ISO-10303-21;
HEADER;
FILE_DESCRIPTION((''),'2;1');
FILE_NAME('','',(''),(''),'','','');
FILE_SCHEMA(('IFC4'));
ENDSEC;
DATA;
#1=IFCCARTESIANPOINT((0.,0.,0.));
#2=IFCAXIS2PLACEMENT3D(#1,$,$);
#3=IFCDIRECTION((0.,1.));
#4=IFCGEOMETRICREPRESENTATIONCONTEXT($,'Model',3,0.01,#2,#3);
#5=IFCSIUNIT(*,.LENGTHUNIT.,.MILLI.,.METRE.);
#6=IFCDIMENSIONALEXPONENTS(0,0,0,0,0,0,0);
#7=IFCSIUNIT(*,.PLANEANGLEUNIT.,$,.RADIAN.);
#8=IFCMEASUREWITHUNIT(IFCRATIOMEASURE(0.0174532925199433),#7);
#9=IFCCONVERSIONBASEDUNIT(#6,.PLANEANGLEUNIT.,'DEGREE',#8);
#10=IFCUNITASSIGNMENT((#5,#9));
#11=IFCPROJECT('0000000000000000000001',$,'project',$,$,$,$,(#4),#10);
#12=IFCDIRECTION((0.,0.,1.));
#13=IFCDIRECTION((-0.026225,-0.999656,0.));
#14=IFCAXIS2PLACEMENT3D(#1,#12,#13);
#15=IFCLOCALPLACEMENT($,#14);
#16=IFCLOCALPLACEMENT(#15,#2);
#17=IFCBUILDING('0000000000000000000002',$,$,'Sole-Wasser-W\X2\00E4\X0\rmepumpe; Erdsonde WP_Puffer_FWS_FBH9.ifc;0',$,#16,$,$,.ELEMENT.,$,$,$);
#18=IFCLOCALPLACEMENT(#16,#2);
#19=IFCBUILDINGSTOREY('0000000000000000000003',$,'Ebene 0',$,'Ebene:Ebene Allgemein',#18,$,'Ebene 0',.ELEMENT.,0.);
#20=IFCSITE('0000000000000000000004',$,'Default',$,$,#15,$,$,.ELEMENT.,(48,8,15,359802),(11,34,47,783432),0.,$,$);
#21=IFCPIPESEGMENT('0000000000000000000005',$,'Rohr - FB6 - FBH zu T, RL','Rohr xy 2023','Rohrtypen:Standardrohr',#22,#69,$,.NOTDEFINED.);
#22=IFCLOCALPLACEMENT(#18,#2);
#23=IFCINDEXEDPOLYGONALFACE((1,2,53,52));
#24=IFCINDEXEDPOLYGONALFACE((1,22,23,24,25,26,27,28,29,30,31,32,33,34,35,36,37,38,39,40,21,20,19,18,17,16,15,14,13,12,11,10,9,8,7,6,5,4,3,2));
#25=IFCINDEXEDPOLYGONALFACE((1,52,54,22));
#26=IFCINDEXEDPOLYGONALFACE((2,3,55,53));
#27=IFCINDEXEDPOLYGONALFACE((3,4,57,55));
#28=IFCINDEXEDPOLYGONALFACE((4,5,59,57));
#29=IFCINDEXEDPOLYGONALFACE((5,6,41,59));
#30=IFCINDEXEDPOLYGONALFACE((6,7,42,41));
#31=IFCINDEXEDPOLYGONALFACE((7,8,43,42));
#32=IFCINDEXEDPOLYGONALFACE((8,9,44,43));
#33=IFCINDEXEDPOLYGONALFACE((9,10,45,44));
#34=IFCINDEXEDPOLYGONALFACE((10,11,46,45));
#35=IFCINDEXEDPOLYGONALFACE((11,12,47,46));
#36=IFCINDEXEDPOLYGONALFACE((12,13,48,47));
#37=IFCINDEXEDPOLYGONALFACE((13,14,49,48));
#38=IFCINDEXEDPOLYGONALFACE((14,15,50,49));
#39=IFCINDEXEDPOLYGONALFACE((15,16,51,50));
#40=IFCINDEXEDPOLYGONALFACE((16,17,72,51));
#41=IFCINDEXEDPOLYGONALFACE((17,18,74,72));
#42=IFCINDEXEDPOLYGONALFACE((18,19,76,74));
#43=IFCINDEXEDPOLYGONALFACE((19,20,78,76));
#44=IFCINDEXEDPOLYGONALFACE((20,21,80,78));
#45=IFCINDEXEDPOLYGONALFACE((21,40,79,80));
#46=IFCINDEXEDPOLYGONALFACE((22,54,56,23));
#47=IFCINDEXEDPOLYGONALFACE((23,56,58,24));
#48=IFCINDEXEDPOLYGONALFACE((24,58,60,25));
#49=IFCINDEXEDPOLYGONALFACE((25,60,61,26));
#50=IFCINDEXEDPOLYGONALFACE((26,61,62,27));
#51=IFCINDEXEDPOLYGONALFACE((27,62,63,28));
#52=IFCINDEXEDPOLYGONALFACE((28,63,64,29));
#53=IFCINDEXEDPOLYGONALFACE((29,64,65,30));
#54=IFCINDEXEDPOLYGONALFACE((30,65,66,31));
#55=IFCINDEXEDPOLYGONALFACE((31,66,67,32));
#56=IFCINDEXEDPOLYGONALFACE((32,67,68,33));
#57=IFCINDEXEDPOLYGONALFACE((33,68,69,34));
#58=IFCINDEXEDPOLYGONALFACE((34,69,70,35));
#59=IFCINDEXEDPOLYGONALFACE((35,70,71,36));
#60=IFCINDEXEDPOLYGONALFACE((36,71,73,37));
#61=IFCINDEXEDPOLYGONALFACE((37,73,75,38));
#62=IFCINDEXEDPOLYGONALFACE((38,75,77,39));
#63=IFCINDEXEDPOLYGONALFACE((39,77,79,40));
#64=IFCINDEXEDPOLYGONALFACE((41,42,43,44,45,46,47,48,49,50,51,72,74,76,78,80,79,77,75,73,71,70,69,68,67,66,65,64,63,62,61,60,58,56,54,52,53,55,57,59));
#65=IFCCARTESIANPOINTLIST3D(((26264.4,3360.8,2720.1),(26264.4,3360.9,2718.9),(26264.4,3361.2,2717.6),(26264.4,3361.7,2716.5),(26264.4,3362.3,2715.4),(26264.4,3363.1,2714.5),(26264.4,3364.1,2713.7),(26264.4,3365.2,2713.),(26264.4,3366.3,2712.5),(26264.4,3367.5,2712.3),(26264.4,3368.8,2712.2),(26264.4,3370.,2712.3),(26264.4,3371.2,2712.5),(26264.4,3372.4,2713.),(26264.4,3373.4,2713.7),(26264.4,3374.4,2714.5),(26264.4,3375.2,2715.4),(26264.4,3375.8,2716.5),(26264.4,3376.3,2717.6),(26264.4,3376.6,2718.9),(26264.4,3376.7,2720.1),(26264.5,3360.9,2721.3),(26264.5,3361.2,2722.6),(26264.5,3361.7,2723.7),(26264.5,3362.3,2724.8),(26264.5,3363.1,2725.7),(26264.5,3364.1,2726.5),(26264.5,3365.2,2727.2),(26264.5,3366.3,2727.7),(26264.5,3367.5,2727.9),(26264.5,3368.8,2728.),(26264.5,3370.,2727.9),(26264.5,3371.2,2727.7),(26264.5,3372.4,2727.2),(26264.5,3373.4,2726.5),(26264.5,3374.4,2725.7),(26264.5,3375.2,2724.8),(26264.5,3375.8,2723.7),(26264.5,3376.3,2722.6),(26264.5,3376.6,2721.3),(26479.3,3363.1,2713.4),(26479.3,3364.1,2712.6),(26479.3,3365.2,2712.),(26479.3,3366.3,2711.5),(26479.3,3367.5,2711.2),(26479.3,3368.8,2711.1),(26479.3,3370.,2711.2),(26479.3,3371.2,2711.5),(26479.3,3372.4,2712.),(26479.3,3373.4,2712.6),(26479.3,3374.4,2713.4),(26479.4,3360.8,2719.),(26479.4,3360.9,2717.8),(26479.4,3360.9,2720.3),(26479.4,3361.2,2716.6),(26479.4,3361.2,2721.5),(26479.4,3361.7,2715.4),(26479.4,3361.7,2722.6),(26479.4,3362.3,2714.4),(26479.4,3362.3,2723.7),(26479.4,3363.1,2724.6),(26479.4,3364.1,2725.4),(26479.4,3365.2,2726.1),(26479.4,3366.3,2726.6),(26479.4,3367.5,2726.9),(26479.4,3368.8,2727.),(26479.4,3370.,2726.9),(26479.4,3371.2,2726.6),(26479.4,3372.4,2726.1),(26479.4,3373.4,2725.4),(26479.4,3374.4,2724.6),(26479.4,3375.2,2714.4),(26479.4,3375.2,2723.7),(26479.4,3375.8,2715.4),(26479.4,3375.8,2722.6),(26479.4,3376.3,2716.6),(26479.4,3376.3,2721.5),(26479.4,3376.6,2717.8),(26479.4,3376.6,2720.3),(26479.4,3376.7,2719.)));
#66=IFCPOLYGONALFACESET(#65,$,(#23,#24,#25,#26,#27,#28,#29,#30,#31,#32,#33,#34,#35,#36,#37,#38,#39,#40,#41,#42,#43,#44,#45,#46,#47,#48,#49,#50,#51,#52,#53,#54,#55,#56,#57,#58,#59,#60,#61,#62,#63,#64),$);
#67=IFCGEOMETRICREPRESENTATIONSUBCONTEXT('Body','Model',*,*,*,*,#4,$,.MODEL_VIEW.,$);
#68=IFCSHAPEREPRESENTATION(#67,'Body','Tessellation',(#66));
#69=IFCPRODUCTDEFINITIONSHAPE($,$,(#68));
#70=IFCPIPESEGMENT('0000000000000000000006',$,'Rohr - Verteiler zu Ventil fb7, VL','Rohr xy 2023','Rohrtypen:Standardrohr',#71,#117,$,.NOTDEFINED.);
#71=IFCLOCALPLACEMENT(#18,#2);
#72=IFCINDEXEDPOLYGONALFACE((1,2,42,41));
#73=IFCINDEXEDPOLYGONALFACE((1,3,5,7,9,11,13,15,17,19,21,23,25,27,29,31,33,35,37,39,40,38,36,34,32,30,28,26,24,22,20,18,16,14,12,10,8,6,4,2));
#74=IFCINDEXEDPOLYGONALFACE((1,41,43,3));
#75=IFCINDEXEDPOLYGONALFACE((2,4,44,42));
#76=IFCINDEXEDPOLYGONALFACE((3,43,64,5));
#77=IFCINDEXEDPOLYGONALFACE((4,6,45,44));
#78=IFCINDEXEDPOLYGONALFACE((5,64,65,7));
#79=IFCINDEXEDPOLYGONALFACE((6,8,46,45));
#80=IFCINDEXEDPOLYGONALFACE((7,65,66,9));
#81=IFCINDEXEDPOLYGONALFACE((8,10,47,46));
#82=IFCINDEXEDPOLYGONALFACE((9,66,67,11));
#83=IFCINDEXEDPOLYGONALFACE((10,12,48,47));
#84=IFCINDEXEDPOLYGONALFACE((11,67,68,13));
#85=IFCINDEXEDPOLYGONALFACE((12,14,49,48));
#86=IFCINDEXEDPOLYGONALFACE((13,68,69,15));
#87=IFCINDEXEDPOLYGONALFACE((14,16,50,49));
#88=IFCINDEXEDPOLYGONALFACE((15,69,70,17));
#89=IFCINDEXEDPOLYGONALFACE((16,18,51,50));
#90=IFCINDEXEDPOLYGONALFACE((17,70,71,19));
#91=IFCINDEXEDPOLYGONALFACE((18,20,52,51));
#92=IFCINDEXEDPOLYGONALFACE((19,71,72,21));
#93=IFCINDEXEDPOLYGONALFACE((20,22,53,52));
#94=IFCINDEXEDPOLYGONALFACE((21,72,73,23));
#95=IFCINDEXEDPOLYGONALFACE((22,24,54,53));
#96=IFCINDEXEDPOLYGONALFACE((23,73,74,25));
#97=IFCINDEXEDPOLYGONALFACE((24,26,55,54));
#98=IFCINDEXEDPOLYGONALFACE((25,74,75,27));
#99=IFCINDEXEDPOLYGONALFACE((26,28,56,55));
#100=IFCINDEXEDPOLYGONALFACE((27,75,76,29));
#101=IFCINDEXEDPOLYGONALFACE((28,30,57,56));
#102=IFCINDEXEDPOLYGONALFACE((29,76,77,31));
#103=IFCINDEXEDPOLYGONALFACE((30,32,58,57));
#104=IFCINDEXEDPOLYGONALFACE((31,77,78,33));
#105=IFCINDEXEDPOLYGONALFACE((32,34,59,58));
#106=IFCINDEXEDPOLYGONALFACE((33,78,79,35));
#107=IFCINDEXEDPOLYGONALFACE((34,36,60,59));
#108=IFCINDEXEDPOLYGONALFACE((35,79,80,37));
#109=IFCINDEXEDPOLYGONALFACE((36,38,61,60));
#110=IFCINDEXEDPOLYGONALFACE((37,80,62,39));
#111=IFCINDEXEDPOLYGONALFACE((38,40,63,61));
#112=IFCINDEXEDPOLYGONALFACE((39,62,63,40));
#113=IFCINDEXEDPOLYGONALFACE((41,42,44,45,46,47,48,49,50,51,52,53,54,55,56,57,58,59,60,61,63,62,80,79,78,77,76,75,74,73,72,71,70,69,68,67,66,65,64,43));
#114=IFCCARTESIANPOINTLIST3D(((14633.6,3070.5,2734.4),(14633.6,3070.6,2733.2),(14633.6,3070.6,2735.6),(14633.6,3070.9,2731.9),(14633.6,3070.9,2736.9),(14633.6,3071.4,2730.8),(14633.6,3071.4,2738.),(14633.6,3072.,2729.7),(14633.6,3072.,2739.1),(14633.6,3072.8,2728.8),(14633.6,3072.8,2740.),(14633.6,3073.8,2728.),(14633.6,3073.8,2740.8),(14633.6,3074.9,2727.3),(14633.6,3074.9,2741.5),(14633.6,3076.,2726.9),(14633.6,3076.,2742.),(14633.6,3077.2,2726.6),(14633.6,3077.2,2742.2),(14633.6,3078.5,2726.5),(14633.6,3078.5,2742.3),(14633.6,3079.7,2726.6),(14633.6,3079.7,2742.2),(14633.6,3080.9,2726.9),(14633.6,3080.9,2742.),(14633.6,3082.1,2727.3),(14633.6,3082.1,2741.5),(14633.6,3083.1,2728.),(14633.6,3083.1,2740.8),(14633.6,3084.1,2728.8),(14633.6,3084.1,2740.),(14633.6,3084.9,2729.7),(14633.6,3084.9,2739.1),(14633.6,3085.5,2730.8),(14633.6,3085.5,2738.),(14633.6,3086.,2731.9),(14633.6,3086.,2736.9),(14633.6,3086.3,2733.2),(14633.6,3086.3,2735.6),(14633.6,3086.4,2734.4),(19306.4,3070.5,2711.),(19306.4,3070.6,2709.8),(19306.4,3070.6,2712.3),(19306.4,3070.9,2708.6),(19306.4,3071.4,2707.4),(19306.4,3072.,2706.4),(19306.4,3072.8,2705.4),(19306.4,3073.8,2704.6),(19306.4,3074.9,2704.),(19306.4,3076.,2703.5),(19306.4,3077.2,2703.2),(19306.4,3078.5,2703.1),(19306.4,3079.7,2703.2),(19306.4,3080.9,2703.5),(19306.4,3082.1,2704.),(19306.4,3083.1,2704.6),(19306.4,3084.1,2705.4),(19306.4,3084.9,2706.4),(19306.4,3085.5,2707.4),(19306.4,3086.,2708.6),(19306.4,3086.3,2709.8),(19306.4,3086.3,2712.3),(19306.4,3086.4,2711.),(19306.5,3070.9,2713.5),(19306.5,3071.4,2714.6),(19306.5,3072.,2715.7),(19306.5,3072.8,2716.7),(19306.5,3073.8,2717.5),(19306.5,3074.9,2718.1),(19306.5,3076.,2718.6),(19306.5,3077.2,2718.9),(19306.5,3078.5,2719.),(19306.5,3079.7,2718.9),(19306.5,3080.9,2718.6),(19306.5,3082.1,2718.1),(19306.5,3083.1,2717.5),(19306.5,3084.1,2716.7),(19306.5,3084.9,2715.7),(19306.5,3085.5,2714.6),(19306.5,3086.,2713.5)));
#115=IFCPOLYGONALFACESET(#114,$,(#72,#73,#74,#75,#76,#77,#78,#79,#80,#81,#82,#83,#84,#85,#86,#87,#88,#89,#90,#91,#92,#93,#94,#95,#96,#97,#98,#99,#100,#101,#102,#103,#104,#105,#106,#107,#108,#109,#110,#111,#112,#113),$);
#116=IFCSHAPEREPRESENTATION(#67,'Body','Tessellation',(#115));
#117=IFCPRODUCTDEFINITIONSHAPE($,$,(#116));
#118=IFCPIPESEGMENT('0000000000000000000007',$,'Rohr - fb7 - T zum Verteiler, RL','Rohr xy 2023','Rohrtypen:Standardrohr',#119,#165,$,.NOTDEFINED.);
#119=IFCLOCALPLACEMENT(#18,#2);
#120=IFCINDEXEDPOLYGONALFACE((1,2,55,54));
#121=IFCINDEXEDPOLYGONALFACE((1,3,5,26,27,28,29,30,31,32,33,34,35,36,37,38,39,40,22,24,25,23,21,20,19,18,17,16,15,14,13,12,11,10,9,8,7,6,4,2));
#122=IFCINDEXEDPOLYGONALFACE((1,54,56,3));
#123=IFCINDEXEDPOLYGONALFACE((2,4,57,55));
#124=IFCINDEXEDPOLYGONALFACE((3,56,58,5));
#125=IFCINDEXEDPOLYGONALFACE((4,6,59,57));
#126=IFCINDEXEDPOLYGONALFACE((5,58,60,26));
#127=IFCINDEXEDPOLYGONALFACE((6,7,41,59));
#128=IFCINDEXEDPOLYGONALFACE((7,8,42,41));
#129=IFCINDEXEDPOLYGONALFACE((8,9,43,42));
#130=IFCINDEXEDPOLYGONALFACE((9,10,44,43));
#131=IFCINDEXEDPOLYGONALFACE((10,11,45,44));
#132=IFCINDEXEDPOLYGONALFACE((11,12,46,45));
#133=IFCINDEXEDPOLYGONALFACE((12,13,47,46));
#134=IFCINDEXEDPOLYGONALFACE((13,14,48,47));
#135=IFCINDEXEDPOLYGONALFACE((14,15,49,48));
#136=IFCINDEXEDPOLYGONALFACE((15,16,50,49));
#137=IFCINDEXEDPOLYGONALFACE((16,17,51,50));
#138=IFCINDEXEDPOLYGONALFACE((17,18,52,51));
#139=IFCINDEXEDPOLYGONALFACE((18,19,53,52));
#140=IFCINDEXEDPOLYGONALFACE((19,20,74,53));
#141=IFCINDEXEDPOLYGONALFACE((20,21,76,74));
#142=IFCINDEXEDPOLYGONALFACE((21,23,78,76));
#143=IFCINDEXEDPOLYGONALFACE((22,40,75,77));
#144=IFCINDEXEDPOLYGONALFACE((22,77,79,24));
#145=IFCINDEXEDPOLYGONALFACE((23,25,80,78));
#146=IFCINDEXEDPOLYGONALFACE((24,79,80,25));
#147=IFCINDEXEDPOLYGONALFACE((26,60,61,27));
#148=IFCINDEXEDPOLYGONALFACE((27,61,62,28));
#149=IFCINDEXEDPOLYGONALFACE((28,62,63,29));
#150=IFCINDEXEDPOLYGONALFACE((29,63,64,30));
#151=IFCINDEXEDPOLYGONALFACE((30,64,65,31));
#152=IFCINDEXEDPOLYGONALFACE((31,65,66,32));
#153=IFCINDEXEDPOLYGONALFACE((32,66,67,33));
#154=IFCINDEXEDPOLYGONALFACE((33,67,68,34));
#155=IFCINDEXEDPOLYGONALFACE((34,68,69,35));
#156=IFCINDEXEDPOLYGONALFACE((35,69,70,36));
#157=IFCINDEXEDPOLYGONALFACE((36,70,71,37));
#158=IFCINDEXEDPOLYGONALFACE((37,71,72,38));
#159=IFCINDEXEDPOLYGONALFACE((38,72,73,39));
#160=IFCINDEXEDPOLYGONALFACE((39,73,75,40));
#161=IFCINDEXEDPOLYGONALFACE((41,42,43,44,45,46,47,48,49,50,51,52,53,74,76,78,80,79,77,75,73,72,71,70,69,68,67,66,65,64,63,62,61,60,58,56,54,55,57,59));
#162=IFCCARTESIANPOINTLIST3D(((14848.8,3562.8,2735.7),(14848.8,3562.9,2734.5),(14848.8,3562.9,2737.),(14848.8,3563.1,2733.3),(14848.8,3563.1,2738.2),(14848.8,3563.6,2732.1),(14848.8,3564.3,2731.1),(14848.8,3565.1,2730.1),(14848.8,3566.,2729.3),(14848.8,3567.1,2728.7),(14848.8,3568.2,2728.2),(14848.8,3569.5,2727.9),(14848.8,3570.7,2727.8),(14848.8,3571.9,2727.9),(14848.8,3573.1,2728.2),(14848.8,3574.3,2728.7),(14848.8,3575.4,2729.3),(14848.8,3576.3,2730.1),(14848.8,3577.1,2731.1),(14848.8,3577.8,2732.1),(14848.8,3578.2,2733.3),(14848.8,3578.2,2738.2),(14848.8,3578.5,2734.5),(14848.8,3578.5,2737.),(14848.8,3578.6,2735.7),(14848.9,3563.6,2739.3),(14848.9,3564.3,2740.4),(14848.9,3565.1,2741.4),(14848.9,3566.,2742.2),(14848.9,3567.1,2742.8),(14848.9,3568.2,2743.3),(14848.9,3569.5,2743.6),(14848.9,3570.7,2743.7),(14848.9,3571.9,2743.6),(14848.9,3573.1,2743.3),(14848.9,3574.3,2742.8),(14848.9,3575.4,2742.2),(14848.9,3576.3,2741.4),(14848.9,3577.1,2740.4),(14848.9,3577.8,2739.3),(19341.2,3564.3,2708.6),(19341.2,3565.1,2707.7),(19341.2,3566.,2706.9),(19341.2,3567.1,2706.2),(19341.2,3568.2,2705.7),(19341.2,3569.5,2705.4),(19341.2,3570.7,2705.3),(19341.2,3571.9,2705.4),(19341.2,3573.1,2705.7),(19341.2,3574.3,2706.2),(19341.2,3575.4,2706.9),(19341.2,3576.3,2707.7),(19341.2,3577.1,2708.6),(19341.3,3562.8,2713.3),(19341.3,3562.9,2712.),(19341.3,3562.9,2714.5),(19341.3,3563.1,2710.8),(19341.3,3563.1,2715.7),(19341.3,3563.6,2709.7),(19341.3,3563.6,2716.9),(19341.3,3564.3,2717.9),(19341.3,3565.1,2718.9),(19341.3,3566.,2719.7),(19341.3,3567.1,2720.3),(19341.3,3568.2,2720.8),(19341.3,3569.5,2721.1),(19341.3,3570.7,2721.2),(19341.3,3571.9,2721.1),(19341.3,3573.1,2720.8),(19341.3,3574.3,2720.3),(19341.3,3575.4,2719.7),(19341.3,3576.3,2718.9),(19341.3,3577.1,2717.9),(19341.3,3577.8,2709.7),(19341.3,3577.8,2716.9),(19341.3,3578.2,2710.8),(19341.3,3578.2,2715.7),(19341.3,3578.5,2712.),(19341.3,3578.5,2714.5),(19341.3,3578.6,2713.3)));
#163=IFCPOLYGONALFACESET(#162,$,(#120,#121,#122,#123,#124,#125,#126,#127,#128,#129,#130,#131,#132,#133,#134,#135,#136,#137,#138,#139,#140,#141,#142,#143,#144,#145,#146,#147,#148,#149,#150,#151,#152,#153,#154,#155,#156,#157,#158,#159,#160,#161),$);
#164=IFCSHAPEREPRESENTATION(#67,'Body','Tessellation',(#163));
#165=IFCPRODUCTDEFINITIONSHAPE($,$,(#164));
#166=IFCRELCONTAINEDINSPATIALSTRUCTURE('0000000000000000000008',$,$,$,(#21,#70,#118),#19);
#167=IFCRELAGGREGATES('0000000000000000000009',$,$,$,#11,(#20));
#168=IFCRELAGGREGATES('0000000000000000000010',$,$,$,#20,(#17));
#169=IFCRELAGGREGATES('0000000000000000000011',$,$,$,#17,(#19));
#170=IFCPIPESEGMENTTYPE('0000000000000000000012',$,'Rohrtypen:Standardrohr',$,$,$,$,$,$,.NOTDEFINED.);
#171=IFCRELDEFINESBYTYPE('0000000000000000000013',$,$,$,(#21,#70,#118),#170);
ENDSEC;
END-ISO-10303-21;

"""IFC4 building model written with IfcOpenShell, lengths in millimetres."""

from ifc_helpers import new_model, entity, si_unit, converted_unit, direction, frame, origin, place, context, subcontext, project, spatial, indexed_curve, outline, extrude, type_object, element, save


model = new_model("IFC4")

# Units and contexts
model_context = context("Model", 3, precision=0.01, world=origin(), true_north=direction((0.0, 1.0)))
body_context = subcontext(model_context, "Body", "Model", "MODEL_VIEW")
ifc_project = project(units=[si_unit("LENGTHUNIT", "METRE", prefix="MILLI"), converted_unit("PLANEANGLEUNIT", "DEGREE", entity("IfcRatioMeasure", 0.0174532925199433), si_unit("PLANEANGLEUNIT", "RADIAN"), dimensions=[0, 0, 0, 0, 0, 0, 0])], contexts=[model_context])

# Site, building, storey
site_placement = place(None, frame((0.0, 0.0, 0.0), z_axis=(0.0, 0.0, 1.0), x_axis=(-0.026225, -0.999656, 0.0)))
site = spatial("IfcSite", under=ifc_project, at=site_placement, Name="Default", CompositionType="ELEMENT", RefLatitude=(48, 8, 15, 359802), RefLongitude=(11, 34, 47, 783432), RefElevation=0.0)
building_placement = place(site_placement, origin())
building = spatial("IfcBuilding", under=site, at=building_placement, Description="Sole-Wasser-Wärmepumpe; Erdsonde WP_Puffer_FWS_FBH9.ifc;0", CompositionType="ELEMENT")
storey_placement = place(building_placement, origin())
storey = spatial("IfcBuildingStorey", under=building, at=storey_placement, Name="Ebene 0", ObjectType="Ebene:Ebene Allgemein", LongName="Ebene 0", CompositionType="ELEMENT", Elevation=0.0)

# Pipe segments
pipe_segment_type = type_object("IfcPipeSegmentType", Name="Rohrtypen:Standardrohr", PredefinedType="NOTDEFINED")
pipe_segment_1_placement = place(storey_placement, origin())
element("IfcPipeSegment", 1, at=pipe_segment_1_placement, inside=storey, type_object=pipe_segment_type, Name="Rohr - FB6 - FBH zu T, RL", Description="Rohr xy 2023", ObjectType="Rohrtypen:Standardrohr", PredefinedType="NOTDEFINED", context=body_context, shape_type="SweptSolid", body=[
    extrude(outline(indexed_curve([(7.9, 0.0), (7.8, 1.2), (7.6, 2.5), (7.1, 3.6), (6.4, 4.7), (5.6, 5.6), (4.7, 6.4), (3.6, 7.1), (2.5, 7.6), (1.2, 7.8), (0.0, 7.9), (-1.2, 7.8), (-2.5, 7.6), (-3.6, 7.1), (-4.7, 6.4), (-5.6, 5.6), (-6.4, 4.7), (-7.1, 3.6), (-7.6, 2.5), (-7.8, 1.2), (-7.9, 0.0), (-7.8, -1.2), (-7.6, -2.5), (-7.1, -3.6), (-6.4, -4.7), (-5.6, -5.6), (-4.7, -6.4), (-3.6, -7.1), (-2.5, -7.6), (-1.2, -7.8), (0.0, -7.9), (1.2, -7.8), (2.5, -7.6), (3.6, -7.1), (4.7, -6.4), (5.6, -5.6), (6.4, -4.7), (7.1, -3.6), (7.6, -2.5), (7.8, -1.2), (7.9, 0.0)], self_intersect=False)), frame((26479.4, 3368.8, 2719.0), z_axis=(-0.999988, 0.0, 0.005), x_axis=(0.0, 1.0, 0.0)), (0.0, 0.0, 1.0), 214.9),
])
pipe_segment_2_placement = place(storey_placement, origin())
element("IfcPipeSegment", 2, at=pipe_segment_2_placement, inside=storey, type_object=pipe_segment_type, Name="Rohr - Verteiler zu Ventil fb7, VL", Description="Rohr xy 2023", ObjectType="Rohrtypen:Standardrohr", PredefinedType="NOTDEFINED", context=body_context, shape_type="SweptSolid", body=[
    extrude(outline(indexed_curve([(7.9, 0.0), (7.8, 1.2), (7.6, 2.5), (7.1, 3.6), (6.4, 4.7), (5.6, 5.6), (4.7, 6.4), (3.6, 7.1), (2.5, 7.6), (1.2, 7.8), (0.0, 7.9), (-1.2, 7.8), (-2.5, 7.6), (-3.6, 7.1), (-4.7, 6.4), (-5.6, 5.6), (-6.4, 4.7), (-7.1, 3.6), (-7.6, 2.5), (-7.8, 1.2), (-7.9, 0.0), (-7.8, -1.2), (-7.6, -2.5), (-7.1, -3.6), (-6.4, -4.7), (-5.6, -5.6), (-4.7, -6.4), (-3.6, -7.1), (-2.5, -7.6), (-1.2, -7.8), (0.0, -7.9), (1.2, -7.8), (2.5, -7.6), (3.6, -7.1), (4.7, -6.4), (5.6, -5.6), (6.4, -4.7), (7.1, -3.6), (7.6, -2.5), (7.8, -1.2), (7.9, 0.0)], self_intersect=False)), frame((19306.4, 3078.5, 2711.0), z_axis=(-0.999988, 0.0, 0.005), x_axis=(0.0, 1.0, 0.0)), (0.0, 0.0, 1.0), 4672.9),
])
pipe_segment_3_placement = place(storey_placement, origin())
element("IfcPipeSegment", 3, at=pipe_segment_3_placement, inside=storey, type_object=pipe_segment_type, Name="Rohr - fb7 - T zum Verteiler, RL", Description="Rohr xy 2023", ObjectType="Rohrtypen:Standardrohr", PredefinedType="NOTDEFINED", context=body_context, shape_type="SweptSolid", body=[
    extrude(outline(indexed_curve([(7.9, 0.0), (7.8, 1.2), (7.6, 2.5), (7.1, 3.6), (6.4, 4.7), (5.6, 5.6), (4.7, 6.4), (3.6, 7.1), (2.5, 7.6), (1.2, 7.8), (0.0, 7.9), (-1.2, 7.8), (-2.5, 7.6), (-3.6, 7.1), (-4.7, 6.4), (-5.6, 5.6), (-6.4, 4.7), (-7.1, 3.6), (-7.6, 2.5), (-7.8, 1.2), (-7.9, 0.0), (-7.8, -1.2), (-7.6, -2.5), (-7.1, -3.6), (-6.4, -4.7), (-5.6, -5.6), (-4.7, -6.4), (-3.6, -7.1), (-2.5, -7.6), (-1.2, -7.8), (0.0, -7.9), (1.2, -7.8), (2.5, -7.6), (3.6, -7.1), (4.7, -6.4), (5.6, -5.6), (6.4, -4.7), (7.1, -3.6), (7.6, -2.5), (7.8, -1.2), (7.9, 0.0)], self_intersect=False)), frame((14848.8, 3570.7, 2735.7), z_axis=(0.999988, 0.0, -0.005), x_axis=(0.0, 1.0, 0.0)), (0.0, 0.0, 1.0), 4492.5),
])

save(model, "model.ifc")
